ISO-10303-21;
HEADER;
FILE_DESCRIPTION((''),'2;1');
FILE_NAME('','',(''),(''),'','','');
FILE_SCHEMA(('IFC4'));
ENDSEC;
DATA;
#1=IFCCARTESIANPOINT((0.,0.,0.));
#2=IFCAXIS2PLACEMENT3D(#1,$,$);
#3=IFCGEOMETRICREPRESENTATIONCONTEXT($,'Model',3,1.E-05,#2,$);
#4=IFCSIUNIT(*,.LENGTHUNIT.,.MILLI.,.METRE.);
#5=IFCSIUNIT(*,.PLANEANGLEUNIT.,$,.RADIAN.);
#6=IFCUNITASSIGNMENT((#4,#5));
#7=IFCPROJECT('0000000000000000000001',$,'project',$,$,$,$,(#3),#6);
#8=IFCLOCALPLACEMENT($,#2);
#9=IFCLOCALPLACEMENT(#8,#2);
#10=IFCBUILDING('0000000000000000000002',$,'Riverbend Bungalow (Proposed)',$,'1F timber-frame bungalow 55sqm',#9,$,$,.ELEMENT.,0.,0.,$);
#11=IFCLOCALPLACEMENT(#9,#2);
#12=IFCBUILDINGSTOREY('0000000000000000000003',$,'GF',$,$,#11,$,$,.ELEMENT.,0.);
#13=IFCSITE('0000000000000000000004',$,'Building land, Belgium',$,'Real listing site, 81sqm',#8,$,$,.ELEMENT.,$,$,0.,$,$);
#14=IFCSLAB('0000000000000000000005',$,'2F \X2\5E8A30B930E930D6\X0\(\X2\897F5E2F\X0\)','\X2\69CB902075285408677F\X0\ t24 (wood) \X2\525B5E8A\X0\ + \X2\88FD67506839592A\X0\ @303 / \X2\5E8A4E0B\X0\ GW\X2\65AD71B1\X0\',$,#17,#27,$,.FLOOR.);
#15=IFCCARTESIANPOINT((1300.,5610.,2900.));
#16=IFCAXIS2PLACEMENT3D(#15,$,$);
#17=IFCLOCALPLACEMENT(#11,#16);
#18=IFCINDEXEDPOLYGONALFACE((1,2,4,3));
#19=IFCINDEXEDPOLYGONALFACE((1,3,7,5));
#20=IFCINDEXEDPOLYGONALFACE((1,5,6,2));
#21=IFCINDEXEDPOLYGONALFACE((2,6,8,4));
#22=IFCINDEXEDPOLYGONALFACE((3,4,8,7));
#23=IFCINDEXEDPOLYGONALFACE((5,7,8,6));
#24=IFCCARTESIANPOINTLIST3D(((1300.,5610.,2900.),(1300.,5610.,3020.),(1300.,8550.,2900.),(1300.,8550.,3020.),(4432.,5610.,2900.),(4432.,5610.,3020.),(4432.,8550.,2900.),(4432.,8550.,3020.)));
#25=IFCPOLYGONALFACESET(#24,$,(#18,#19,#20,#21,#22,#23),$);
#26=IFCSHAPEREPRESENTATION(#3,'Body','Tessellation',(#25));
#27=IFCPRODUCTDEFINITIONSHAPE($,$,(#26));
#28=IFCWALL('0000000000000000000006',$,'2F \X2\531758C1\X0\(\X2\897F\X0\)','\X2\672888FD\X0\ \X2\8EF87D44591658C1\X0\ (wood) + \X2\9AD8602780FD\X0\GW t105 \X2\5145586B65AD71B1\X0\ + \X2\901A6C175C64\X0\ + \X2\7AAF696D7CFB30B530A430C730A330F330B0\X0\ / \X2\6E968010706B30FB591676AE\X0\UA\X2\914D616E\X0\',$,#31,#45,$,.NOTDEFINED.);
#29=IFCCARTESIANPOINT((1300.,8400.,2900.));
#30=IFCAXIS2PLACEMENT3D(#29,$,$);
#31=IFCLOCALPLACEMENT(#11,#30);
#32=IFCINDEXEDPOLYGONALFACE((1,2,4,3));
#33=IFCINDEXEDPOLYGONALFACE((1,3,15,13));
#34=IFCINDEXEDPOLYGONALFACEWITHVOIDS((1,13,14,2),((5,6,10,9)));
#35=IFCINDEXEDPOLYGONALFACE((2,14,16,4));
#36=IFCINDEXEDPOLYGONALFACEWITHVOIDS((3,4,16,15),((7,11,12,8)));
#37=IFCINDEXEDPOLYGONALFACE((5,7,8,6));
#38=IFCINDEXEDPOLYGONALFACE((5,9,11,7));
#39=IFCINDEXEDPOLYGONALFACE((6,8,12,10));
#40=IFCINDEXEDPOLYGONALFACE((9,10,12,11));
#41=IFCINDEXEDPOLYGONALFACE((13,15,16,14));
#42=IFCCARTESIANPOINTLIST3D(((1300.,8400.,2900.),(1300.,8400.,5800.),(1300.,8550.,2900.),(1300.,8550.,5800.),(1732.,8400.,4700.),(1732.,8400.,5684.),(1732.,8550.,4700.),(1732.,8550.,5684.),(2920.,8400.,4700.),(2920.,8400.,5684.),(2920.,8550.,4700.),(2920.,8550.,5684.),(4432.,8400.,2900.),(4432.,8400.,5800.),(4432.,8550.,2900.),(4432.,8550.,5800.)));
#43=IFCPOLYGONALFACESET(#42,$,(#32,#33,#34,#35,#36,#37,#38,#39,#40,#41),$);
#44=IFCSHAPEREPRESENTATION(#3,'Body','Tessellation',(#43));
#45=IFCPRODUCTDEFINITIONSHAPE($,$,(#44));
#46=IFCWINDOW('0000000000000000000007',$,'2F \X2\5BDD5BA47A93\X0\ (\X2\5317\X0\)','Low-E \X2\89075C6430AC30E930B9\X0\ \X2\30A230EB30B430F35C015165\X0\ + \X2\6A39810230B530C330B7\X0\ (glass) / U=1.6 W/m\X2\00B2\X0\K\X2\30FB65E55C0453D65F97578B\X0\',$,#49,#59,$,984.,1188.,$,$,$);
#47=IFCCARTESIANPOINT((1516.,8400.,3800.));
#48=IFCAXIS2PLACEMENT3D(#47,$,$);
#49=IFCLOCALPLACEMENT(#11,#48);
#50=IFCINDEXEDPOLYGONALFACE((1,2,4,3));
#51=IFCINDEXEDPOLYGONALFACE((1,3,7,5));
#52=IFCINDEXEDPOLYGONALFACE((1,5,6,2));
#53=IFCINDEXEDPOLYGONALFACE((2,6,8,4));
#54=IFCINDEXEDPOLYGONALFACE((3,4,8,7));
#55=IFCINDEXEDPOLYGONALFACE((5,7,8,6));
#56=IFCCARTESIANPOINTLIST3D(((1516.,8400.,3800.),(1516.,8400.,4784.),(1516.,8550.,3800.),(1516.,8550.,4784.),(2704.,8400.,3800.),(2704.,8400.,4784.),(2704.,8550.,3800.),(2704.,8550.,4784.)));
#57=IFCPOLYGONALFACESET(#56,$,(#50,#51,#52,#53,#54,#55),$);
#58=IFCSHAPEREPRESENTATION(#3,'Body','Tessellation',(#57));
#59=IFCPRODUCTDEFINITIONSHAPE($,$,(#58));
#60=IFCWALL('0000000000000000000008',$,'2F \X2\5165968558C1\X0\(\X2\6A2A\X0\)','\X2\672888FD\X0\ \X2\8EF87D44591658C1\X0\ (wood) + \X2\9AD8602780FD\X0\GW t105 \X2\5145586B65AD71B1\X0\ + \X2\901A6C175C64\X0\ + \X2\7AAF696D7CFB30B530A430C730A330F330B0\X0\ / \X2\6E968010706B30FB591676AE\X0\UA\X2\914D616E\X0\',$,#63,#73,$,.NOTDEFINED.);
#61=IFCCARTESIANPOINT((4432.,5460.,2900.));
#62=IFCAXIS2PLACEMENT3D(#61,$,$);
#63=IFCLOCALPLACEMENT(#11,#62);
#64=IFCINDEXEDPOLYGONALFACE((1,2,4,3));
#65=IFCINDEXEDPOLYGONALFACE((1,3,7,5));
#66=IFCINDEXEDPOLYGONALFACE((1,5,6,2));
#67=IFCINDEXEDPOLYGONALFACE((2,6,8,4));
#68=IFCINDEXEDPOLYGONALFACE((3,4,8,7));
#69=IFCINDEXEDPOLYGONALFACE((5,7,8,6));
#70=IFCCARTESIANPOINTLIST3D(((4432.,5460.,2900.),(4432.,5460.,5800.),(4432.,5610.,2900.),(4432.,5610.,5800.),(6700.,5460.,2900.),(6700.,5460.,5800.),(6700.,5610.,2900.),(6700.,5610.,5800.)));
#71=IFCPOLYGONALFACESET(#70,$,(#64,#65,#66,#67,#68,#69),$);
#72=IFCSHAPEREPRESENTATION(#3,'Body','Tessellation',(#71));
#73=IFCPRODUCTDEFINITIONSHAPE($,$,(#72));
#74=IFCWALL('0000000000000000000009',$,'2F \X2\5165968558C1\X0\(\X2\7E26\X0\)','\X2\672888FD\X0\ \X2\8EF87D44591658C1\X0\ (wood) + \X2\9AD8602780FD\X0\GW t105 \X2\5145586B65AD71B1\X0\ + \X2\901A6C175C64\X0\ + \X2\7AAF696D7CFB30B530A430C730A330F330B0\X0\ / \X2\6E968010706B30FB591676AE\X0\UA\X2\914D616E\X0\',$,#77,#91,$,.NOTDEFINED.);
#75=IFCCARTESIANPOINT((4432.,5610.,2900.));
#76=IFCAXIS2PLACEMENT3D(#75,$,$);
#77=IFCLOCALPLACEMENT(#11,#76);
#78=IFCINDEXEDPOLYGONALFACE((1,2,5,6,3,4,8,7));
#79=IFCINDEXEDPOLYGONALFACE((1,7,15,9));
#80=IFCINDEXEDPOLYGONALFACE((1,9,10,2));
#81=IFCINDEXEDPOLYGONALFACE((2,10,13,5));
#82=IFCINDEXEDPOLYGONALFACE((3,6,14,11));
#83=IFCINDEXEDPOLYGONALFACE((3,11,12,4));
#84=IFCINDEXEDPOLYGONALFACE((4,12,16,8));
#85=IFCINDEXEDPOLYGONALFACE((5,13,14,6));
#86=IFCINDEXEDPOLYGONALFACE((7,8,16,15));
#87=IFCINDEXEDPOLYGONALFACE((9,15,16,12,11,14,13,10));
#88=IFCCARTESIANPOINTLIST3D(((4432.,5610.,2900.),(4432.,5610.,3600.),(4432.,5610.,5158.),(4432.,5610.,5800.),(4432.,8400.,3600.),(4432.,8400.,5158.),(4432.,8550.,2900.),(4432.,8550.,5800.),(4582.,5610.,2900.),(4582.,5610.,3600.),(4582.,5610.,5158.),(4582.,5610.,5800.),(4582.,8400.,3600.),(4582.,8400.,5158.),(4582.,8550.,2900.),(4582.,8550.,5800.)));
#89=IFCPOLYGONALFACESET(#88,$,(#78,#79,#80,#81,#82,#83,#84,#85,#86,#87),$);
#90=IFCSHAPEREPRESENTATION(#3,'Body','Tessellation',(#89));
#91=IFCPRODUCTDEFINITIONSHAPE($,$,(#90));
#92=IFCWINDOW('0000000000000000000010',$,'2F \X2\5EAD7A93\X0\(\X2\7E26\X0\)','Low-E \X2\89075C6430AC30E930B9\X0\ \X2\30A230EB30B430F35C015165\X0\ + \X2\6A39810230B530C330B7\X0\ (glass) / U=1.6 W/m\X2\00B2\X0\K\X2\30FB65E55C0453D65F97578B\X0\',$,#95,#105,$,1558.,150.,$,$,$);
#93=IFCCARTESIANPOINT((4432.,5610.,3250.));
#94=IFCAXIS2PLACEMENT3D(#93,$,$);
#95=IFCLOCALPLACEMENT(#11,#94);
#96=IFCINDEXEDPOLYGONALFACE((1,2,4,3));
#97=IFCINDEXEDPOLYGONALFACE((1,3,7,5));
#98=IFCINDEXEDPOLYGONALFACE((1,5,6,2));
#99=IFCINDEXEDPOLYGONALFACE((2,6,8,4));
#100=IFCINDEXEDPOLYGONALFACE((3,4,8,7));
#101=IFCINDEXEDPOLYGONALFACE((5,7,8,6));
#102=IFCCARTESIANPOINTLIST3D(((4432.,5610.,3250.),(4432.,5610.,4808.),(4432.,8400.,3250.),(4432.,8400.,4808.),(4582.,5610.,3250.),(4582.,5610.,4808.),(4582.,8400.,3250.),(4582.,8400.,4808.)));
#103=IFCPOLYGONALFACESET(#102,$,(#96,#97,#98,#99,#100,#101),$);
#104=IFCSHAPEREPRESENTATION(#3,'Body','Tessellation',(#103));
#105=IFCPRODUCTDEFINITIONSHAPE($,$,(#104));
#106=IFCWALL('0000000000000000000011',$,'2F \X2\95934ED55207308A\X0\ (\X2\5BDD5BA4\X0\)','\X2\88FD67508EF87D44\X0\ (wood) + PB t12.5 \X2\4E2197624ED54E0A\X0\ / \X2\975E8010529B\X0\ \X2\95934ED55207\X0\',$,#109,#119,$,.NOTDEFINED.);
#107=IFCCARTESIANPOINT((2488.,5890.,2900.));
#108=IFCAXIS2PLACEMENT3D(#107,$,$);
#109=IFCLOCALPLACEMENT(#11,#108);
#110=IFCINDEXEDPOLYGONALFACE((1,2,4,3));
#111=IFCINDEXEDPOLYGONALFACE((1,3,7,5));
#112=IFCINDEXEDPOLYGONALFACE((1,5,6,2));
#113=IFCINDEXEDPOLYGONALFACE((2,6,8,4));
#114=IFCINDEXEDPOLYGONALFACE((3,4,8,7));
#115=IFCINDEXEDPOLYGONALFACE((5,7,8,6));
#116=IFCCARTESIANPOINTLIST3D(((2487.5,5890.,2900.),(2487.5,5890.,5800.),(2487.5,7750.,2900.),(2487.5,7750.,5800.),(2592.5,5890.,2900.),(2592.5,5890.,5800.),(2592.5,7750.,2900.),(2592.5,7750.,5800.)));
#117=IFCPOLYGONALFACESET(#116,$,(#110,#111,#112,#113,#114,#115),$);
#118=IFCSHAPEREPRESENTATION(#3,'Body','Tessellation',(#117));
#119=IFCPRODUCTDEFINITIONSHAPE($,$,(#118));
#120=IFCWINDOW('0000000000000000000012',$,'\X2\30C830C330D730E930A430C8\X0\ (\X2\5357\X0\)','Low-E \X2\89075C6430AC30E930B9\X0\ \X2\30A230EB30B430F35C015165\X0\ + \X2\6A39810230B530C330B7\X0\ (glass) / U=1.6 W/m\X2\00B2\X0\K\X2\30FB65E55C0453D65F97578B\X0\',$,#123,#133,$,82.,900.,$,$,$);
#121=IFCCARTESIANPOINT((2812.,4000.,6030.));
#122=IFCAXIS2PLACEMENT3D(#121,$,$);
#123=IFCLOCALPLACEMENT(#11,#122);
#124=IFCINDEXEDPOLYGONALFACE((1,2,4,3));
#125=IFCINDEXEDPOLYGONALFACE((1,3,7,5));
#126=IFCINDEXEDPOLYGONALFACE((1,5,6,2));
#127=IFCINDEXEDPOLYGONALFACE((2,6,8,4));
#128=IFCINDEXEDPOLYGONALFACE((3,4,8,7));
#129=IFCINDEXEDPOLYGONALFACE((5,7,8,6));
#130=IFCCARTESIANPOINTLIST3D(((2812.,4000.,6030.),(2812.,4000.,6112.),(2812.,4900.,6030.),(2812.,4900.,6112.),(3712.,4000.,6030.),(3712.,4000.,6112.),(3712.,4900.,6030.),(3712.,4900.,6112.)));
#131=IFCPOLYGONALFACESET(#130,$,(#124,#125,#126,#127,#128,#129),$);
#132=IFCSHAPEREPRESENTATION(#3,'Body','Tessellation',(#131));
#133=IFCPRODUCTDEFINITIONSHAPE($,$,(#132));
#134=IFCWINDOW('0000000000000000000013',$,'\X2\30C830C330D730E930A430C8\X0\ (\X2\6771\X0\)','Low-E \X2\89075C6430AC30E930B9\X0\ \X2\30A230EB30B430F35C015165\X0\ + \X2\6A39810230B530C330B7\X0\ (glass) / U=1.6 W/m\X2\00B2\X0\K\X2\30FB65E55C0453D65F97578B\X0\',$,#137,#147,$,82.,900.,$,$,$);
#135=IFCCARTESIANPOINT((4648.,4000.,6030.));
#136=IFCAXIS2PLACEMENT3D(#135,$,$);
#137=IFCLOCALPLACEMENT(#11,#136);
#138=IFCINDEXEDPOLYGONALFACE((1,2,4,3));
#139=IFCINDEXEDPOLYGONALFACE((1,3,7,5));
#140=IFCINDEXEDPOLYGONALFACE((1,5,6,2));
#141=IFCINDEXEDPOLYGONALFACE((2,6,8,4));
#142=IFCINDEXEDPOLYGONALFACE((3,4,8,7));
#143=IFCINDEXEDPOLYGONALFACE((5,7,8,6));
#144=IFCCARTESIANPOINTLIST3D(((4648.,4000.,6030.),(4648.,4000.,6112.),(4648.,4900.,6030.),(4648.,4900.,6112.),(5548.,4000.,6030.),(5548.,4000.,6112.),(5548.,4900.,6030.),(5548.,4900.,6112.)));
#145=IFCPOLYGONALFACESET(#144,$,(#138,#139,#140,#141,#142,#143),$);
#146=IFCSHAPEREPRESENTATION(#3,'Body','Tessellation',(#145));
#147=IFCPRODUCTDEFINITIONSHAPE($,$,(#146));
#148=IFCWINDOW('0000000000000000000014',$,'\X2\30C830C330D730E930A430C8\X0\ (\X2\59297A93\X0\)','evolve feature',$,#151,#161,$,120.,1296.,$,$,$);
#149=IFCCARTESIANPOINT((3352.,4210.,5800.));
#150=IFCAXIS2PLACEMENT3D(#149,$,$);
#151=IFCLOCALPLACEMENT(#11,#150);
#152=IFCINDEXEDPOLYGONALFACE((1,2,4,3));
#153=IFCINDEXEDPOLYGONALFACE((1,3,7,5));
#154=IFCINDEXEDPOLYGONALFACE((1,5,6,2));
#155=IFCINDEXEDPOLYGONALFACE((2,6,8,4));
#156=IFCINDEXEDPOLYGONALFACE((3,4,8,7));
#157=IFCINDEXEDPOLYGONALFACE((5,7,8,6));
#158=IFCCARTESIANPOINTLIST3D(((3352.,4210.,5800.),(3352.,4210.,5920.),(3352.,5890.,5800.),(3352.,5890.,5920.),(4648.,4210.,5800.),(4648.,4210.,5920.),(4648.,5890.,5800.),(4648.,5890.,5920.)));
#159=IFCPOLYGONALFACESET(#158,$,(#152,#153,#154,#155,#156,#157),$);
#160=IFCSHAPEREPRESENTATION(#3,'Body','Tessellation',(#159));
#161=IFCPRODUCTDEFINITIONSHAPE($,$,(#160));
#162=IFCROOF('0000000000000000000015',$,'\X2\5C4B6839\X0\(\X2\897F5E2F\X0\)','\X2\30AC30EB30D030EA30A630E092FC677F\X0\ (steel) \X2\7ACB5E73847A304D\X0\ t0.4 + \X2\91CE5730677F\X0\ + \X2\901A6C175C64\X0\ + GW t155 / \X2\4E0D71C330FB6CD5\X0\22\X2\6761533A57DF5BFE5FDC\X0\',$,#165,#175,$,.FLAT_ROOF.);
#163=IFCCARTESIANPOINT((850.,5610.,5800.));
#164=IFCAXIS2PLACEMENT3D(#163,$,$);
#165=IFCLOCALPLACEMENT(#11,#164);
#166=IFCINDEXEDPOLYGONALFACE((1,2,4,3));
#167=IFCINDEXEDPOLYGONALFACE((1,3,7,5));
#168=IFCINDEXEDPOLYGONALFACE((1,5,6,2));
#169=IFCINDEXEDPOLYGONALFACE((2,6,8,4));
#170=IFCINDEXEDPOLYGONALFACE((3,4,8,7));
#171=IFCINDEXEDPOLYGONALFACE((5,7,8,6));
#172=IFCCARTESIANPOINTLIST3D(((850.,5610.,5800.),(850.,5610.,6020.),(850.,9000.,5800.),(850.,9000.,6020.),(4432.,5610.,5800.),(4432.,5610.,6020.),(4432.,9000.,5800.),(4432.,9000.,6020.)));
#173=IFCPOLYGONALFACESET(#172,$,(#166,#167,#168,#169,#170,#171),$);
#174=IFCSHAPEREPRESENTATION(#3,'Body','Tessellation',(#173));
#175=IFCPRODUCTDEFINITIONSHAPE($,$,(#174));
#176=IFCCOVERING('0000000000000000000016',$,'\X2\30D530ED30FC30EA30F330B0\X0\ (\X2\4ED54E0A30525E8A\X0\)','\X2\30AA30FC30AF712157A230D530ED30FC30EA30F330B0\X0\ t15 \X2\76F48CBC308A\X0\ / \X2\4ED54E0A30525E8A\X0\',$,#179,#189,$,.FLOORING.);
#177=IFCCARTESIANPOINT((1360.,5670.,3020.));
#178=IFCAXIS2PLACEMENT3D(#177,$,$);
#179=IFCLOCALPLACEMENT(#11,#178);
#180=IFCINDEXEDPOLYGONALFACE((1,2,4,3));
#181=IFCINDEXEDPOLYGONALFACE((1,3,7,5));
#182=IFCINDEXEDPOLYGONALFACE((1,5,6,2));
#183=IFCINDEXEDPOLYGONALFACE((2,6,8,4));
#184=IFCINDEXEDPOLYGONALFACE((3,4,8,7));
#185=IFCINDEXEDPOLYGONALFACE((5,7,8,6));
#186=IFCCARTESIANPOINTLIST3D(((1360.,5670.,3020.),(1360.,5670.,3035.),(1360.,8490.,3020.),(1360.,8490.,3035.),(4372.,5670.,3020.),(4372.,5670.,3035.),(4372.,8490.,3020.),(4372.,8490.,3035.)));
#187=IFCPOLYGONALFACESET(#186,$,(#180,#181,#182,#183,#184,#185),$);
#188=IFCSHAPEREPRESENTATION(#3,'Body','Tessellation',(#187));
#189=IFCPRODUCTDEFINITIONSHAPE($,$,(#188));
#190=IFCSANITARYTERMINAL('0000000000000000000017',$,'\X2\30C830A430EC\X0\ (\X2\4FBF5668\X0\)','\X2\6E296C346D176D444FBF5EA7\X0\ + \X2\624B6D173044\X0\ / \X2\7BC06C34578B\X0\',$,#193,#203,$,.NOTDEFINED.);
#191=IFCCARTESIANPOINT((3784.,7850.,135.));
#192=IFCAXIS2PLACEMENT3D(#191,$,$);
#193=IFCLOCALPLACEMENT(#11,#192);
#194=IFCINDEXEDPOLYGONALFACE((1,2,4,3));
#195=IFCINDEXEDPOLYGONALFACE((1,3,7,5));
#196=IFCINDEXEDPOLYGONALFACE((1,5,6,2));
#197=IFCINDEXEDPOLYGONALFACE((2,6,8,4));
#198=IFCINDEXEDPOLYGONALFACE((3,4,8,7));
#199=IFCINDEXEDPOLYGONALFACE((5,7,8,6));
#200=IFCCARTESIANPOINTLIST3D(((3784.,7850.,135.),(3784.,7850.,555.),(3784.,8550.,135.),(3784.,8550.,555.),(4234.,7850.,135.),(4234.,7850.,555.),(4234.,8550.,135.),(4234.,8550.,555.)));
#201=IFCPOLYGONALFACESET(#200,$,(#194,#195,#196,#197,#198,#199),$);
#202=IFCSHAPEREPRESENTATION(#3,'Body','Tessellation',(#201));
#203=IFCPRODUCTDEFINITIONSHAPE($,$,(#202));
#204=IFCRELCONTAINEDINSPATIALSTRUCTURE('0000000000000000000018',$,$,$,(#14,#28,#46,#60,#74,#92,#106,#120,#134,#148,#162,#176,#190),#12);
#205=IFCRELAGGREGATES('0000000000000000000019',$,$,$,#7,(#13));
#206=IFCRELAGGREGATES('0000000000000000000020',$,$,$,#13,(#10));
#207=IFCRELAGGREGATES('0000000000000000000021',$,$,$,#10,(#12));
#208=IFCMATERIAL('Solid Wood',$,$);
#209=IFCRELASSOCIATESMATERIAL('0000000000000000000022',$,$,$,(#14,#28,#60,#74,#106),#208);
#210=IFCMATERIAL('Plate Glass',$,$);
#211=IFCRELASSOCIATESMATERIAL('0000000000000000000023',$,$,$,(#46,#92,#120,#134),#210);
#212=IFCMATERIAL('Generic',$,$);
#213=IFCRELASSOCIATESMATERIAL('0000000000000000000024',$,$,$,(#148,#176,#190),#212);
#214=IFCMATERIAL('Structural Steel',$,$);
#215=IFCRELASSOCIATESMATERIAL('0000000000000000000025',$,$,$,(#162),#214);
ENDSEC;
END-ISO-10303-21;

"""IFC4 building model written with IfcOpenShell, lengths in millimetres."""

from ifc_helpers import new_model, si_unit, frame, frame_2d, origin, place, context, project, spatial, rectangle, extrude, material, element, fill, save


model = new_model("IFC4")

# Units and contexts
model_context = context("Model", 3, precision=1e-05, world=origin())
ifc_project = project(units=[si_unit("LENGTHUNIT", "METRE", prefix="MILLI"), si_unit("PLANEANGLEUNIT", "RADIAN")], contexts=[model_context])

# Site, building, storey
site_placement = place(None, origin())
site = spatial("IfcSite", under=ifc_project, at=site_placement, Name="Building land, Belgium", ObjectType="Real listing site, 81sqm", CompositionType="ELEMENT", RefElevation=0.0)
building_placement = place(site_placement, origin())
building = spatial("IfcBuilding", under=site, at=building_placement, Name="Riverbend Bungalow (Proposed)", ObjectType="1F timber-frame bungalow 55sqm", CompositionType="ELEMENT", ElevationOfRefHeight=0.0, ElevationOfTerrain=0.0)
storey_placement = place(building_placement, origin())
storey = spatial("IfcBuildingStorey", under=building, at=storey_placement, Name="GF", CompositionType="ELEMENT", Elevation=0.0)

# Slab
ifc_material_1 = material(Name="Solid Wood")
slab_placement = place(storey_placement, frame((1300.0, 5610.0, 2900.0)))
element("IfcSlab", 1, at=slab_placement, inside=storey, material=ifc_material_1, Name="2F 床スラブ(西帯)", Description="構造用合板 t24 (wood) 剛床 + 製材根太 @303 / 床下 GW断熱", PredefinedType="FLOOR", context=model_context, shape_type="SweptSolid", body=[
    extrude(rectangle(XDim=3132.0, YDim=2940.0, at=frame_2d((1566.0, 1470.0))), frame((1300.0, 5610.0, 2900.0)), (0.0, 0.0, 1.0), 120.0),
])

# Wall, opening, window
wall_1_placement = place(storey_placement, frame((1300.0, 8400.0, 2900.0)))
wall_1 = element("IfcWall", 2, at=wall_1_placement, inside=storey, material=ifc_material_1, Name="2F 北壁(西)", Description="木製 軸組外壁 (wood) + 高性能GW t105 充填断熱 + 通気層 + 窯業系サイディング / 準耐火・外皮UA配慮", PredefinedType="NOTDEFINED", context=model_context, shape_type="SweptSolid", body=[
    extrude(rectangle(XDim=3132.0, YDim=150.0, at=frame_2d((1566.0, 75.0))), frame((1300.0, 8400.0, 2900.0)), (0.0, 0.0, 1.0), 2900.0),
])
opening_1_placement = place(storey_placement, frame((1516.0, 8400.0, 3800.0)))
opening_1 = element("IfcOpeningElement", 3, at=opening_1_placement, cuts=wall_1, PredefinedType="NOTDEFINED", context=model_context, shape_type="SweptSolid", body=[
    extrude(rectangle(XDim=1188.0, YDim=150.0, at=frame_2d((594.0, 75.0))), frame((1516.0, 8400.0, 3800.0)), (0.0, 0.0, 1.0), 984.0),
])
ifc_material_2 = material(Name="Plate Glass")
window_1_placement = place(storey_placement, frame((1516.0, 8400.0, 3800.0)))
window_1 = element("IfcWindow", 4, at=window_1_placement, inside=storey, material=ifc_material_2, Name="2F 寝室窓 (北)", Description="Low-E 複層ガラス アルゴン封入 + 樹脂サッシ (glass) / U=1.6 W/m²K・日射取得型", OverallHeight=984.0, OverallWidth=1188.0, context=model_context, shape_type="SweptSolid", body=[
    extrude(rectangle(XDim=1188.0, YDim=150.0, at=frame_2d((594.0, 75.0))), frame((1516.0, 8400.0, 3800.0)), (0.0, 0.0, 1.0), 984.0),
])
fill(opening_1, window_1)

# Wall
wall_2_placement = place(storey_placement, frame((4432.0, 5460.0, 2900.0)))
element("IfcWall", 5, at=wall_2_placement, inside=storey, material=ifc_material_1, Name="2F 入隅壁(横)", Description="木製 軸組外壁 (wood) + 高性能GW t105 充填断熱 + 通気層 + 窯業系サイディング / 準耐火・外皮UA配慮", PredefinedType="NOTDEFINED", context=model_context, shape_type="SweptSolid", body=[
    extrude(rectangle(XDim=2268.0, YDim=150.0, at=frame_2d((1134.0, 75.0))), frame((4432.0, 5460.0, 2900.0)), (0.0, 0.0, 1.0), 2900.0),
])

# Wall, opening, window
wall_3_placement = place(storey_placement, frame((4432.0, 5610.0, 2900.0)))
wall_3 = element("IfcWall", 6, at=wall_3_placement, inside=storey, material=ifc_material_1, Name="2F 入隅壁(縦)", Description="木製 軸組外壁 (wood) + 高性能GW t105 充填断熱 + 通気層 + 窯業系サイディング / 準耐火・外皮UA配慮", PredefinedType="NOTDEFINED", context=model_context, shape_type="SweptSolid", body=[
    extrude(rectangle(XDim=150.0, YDim=2940.0, at=frame_2d((75.0, 1470.0))), frame((4432.0, 5610.0, 2900.0)), (0.0, 0.0, 1.0), 2900.0),
])
opening_2_placement = place(storey_placement, frame((4432.0, 5610.0, 3250.0)))
opening_2 = element("IfcOpeningElement", 7, at=opening_2_placement, cuts=wall_3, PredefinedType="NOTDEFINED", context=model_context, shape_type="SweptSolid", body=[
    extrude(rectangle(XDim=150.0, YDim=2790.0, at=frame_2d((75.0, 1395.0))), frame((4432.0, 5610.0, 3250.0)), (0.0, 0.0, 1.0), 1558.0),
])
window_2_placement = place(storey_placement, frame((4432.0, 5610.0, 3250.0)))
window_2 = element("IfcWindow", 8, at=window_2_placement, inside=storey, material=ifc_material_2, Name="2F 庭窓(縦)", Description="Low-E 複層ガラス アルゴン封入 + 樹脂サッシ (glass) / U=1.6 W/m²K・日射取得型", OverallHeight=1558.0, OverallWidth=150.0, context=model_context, shape_type="SweptSolid", body=[
    extrude(rectangle(XDim=150.0, YDim=2790.0, at=frame_2d((75.0, 1395.0))), frame((4432.0, 5610.0, 3250.0)), (0.0, 0.0, 1.0), 1558.0),
])
fill(opening_2, window_2)

# Wall
wall_4_placement = place(storey_placement, frame((2488.0, 5890.0, 2900.0)))
element("IfcWall", 9, at=wall_4_placement, inside=storey, material=ifc_material_1, Name="2F 間仕切り (寝室)", Description="製材軸組 (wood) + PB t12.5 両面仕上 / 非耐力 間仕切", PredefinedType="NOTDEFINED", context=model_context, shape_type="SweptSolid", body=[
    extrude(rectangle(XDim=105.0, YDim=1860.0, at=frame_2d((52.0, 930.0))), frame((2488.0, 5890.0, 2900.0)), (0.0, 0.0, 1.0), 2900.0),
])

# Windows
window_3_placement = place(storey_placement, frame((2812.0, 4000.0, 6030.0)))
element("IfcWindow", 10, at=window_3_placement, inside=storey, material=ifc_material_2, Name="トップライト (南)", Description="Low-E 複層ガラス アルゴン封入 + 樹脂サッシ (glass) / U=1.6 W/m²K・日射取得型", OverallHeight=82.0, OverallWidth=900.0, context=model_context, shape_type="SweptSolid", body=[
    extrude(rectangle(XDim=900.0, YDim=900.0, at=frame_2d((450.0, 450.0))), frame((2812.0, 4000.0, 6030.0)), (0.0, 0.0, 1.0), 82.0),
])
window_4_placement = place(storey_placement, frame((4648.0, 4000.0, 6030.0)))
element("IfcWindow", 11, at=window_4_placement, inside=storey, material=ifc_material_2, Name="トップライト (東)", Description="Low-E 複層ガラス アルゴン封入 + 樹脂サッシ (glass) / U=1.6 W/m²K・日射取得型", OverallHeight=82.0, OverallWidth=900.0, context=model_context, shape_type="SweptSolid", body=[
    extrude(rectangle(XDim=900.0, YDim=900.0, at=frame_2d((450.0, 450.0))), frame((4648.0, 4000.0, 6030.0)), (0.0, 0.0, 1.0), 82.0),
])
ifc_material_3 = material(Name="Generic")
window_5_placement = place(storey_placement, frame((3352.0, 4210.0, 5800.0)))
element("IfcWindow", 12, at=window_5_placement, inside=storey, material=ifc_material_3, Name="トップライト (天窓)", Description="evolve feature", OverallHeight=120.0, OverallWidth=1296.0, context=model_context, shape_type="SweptSolid", body=[
    extrude(rectangle(XDim=1296.0, YDim=1680.0, at=frame_2d((648.0, 840.0))), frame((3352.0, 4210.0, 5800.0)), (0.0, 0.0, 1.0), 120.0),
])

# Roof
ifc_material_4 = material(Name="Structural Steel")
for number, where, name in (
    (13, (850.0, 5610.0, 5800.0), "屋根(西帯)"),
):
    element("IfcRoof", number, at=place(storey_placement, frame(where)), inside=storey, material=ifc_material_4, Name=name, Description="ガルバリウム鋼板 (steel) 立平葺き t0.4 + 野地板 + 通気層 + GW t155 / 不燃・法22条区域対応", PredefinedType="FLAT_ROOF", context=model_context, shape_type="SweptSolid", body=[
        extrude(rectangle(XDim=3582.0, YDim=3390.0, at=frame_2d((1791.0, 1695.0))), frame((850.0, 5610.0, 5800.0)), (0.0, 0.0, 1.0), 220.0),
    ])

# Covering
covering_placement = place(storey_placement, frame((1360.0, 5670.0, 3020.0)))
element("IfcCovering", 14, at=covering_placement, inside=storey, material=ifc_material_3, Name="フローリング (仕上げ床)", Description="オーク無垢フローリング t15 直貼り / 仕上げ床", PredefinedType="FLOORING", context=model_context, shape_type="SweptSolid", body=[
    extrude(rectangle(XDim=3012.0, YDim=2820.0, at=frame_2d((1506.0, 1410.0))), frame((1360.0, 5670.0, 3020.0)), (0.0, 0.0, 1.0), 15.0),
])

# Sanitary terminal
sanitary_terminal_placement = place(storey_placement, frame((3784.0, 7850.0, 135.0)))
element("IfcSanitaryTerminal", 15, at=sanitary_terminal_placement, inside=storey, material=ifc_material_3, Name="トイレ (便器)", Description="温水洗浄便座 + 手洗い / 節水型", PredefinedType="NOTDEFINED", context=model_context, shape_type="SweptSolid", body=[
    extrude(rectangle(XDim=450.0, YDim=700.0, at=frame_2d((225.0, 350.0))), frame((3784.0, 7850.0, 135.0)), (0.0, 0.0, 1.0), 420.0),
])

save(model, "model.ifc")
